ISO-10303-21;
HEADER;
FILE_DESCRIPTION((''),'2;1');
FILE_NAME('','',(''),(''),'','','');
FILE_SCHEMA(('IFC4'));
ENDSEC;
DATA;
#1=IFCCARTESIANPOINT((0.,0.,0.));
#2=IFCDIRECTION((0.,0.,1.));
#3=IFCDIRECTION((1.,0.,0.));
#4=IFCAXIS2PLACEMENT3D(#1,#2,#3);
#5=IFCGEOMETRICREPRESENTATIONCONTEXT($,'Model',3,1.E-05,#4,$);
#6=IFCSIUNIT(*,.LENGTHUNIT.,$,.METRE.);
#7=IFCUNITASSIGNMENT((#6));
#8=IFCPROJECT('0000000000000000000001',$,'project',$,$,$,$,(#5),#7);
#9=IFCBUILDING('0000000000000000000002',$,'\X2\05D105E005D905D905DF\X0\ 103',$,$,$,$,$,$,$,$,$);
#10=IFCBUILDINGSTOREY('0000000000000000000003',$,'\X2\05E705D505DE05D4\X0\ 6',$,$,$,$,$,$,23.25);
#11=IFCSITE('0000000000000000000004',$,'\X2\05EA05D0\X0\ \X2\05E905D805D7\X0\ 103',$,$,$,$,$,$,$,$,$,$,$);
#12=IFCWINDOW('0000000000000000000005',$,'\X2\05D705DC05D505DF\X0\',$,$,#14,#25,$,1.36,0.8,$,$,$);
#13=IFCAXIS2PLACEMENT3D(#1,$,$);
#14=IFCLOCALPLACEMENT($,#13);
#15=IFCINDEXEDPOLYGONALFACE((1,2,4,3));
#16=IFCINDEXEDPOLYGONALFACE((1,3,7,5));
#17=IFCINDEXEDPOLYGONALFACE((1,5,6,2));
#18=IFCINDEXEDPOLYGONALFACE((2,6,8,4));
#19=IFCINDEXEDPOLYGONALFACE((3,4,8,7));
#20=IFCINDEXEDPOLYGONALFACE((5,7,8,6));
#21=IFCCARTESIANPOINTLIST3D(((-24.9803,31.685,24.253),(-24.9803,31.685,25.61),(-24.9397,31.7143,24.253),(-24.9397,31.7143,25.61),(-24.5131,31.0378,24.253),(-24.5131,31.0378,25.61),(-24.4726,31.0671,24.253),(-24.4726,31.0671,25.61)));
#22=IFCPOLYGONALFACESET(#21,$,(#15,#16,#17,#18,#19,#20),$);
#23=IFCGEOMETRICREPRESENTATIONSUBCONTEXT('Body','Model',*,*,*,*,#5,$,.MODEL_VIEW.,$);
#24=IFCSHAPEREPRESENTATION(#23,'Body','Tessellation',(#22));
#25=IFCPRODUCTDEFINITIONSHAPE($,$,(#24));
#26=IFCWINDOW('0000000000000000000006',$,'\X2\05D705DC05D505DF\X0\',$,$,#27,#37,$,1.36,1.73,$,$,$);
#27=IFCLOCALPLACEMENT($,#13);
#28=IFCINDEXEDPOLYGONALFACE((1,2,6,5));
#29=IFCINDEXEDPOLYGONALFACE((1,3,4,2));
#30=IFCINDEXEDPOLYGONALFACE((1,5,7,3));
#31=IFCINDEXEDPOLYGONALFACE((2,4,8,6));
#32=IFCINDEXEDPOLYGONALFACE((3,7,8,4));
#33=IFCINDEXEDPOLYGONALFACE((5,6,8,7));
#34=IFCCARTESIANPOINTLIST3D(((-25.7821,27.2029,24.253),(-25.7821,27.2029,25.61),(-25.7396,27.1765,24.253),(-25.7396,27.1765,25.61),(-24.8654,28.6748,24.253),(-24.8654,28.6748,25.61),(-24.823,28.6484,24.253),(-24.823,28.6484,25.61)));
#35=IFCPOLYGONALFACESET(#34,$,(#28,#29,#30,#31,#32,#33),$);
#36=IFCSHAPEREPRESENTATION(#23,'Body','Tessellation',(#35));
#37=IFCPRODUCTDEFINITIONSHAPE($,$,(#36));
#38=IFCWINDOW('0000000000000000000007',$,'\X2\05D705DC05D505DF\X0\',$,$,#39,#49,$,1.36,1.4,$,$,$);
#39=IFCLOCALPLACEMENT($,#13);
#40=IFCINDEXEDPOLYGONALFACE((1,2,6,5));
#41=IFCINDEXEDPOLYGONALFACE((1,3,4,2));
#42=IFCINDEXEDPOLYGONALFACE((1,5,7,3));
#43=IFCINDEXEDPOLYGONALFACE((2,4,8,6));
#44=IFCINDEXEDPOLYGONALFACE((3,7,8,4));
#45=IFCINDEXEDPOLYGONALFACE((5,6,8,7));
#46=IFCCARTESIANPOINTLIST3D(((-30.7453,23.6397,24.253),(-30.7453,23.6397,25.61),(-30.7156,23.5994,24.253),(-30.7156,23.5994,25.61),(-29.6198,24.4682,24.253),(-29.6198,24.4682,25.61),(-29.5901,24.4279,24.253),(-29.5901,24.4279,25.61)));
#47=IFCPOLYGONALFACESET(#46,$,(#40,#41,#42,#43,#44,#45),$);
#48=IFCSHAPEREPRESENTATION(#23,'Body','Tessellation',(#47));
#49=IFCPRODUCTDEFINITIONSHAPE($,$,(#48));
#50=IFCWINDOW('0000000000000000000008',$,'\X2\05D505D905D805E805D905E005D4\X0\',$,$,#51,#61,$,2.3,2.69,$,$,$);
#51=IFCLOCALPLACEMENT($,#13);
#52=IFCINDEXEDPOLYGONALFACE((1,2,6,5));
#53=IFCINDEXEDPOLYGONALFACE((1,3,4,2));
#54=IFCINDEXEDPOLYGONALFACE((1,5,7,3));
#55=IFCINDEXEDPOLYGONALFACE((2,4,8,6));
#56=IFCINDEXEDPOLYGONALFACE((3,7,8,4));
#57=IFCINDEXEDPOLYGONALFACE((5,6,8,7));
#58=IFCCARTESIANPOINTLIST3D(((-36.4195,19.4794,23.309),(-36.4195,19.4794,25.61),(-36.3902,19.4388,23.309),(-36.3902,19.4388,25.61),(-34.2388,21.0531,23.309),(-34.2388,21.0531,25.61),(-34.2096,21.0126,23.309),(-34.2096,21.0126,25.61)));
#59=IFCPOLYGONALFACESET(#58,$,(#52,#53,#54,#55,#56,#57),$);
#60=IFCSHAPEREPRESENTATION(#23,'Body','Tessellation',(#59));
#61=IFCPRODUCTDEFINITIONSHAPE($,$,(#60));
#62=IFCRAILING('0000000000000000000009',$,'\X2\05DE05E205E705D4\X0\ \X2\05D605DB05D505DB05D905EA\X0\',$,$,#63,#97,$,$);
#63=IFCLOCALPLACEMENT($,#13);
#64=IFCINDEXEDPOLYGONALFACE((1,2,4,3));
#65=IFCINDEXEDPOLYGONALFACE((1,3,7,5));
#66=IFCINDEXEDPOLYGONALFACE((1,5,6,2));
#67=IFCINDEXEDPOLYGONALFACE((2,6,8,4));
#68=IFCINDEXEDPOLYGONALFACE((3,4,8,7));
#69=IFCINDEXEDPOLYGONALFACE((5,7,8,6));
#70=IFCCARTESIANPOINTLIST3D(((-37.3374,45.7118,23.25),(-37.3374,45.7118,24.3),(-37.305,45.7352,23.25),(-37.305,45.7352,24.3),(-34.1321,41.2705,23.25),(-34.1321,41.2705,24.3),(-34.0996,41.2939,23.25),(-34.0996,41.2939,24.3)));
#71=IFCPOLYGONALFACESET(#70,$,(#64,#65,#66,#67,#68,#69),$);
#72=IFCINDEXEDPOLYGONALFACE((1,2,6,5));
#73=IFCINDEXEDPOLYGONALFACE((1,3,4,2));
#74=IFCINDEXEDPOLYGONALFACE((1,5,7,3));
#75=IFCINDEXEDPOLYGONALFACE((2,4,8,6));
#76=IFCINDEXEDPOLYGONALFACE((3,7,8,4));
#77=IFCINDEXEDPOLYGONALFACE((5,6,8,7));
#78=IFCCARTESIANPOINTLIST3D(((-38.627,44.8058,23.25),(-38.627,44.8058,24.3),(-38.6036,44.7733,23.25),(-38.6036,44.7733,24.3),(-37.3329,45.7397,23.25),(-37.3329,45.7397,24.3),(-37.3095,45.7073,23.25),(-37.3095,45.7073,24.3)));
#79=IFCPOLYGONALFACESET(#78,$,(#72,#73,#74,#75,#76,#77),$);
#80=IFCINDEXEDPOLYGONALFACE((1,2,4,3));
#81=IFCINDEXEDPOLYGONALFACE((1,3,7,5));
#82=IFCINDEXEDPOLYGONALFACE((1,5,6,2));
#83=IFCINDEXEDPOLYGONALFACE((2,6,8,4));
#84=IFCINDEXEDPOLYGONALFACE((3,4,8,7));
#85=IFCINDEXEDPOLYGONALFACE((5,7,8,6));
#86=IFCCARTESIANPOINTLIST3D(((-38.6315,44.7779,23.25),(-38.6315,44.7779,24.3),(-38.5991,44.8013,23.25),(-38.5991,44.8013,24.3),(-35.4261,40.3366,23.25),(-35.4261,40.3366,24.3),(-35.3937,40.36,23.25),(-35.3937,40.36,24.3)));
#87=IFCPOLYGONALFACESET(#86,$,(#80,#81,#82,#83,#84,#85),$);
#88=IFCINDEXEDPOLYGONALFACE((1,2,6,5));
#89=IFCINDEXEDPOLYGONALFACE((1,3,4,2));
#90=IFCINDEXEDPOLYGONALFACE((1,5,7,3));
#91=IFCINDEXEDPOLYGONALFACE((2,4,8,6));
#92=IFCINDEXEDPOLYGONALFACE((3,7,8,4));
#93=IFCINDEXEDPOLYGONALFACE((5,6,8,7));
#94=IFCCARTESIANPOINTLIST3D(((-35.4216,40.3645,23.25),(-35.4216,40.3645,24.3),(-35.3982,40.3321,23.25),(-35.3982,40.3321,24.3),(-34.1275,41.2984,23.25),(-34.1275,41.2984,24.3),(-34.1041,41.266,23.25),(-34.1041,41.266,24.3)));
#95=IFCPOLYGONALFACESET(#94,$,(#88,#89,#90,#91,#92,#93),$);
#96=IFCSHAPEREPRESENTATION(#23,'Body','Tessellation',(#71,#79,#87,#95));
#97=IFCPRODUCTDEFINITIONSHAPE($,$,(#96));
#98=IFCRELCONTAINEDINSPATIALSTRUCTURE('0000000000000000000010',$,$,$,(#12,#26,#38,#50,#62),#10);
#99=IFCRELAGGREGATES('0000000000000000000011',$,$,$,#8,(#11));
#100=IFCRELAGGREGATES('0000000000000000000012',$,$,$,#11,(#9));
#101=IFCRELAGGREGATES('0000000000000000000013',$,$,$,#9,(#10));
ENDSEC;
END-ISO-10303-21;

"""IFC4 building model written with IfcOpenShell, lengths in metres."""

from ifc_helpers import new_model, si_unit, frame, origin_with_axes, context, subcontext, project, spatial, polyline, outline, extrude, element, save


model = new_model("IFC4")

# Units and contexts
model_context = context("Model", 3, precision=1e-05, world=origin_with_axes())
body_context = subcontext(model_context, "Body", "Model", "MODEL_VIEW")
ifc_project = project(units=[si_unit("LENGTHUNIT", "METRE")], contexts=[model_context])

# Site, building, storey
site = spatial("IfcSite", under=ifc_project, Name="תא שטח 103")
building = spatial("IfcBuilding", under=site, Name="בניין 103")
storey = spatial("IfcBuildingStorey", under=building, Name="קומה 6", Elevation=23.25)

# Windows
element("IfcWindow", 1, inside=storey, Name="חלון", OverallHeight=1.36, OverallWidth=0.8, context=body_context, shape_type="SweptSolid", body=[
    extrude(outline(polyline([(-24.9803, 31.685), (-24.5131, 31.0378), (-24.4726, 31.0671), (-24.9397, 31.7143), (-24.9803, 31.685)])), frame((0.0, 0.0, 24.253)), (0.0, 0.0, 1.0), 1.357),
])
element("IfcWindow", 2, inside=storey, Name="חלון", OverallHeight=1.36, OverallWidth=1.73, context=body_context, shape_type="SweptSolid", body=[
    extrude(outline(polyline([(-24.8654, 28.6748), (-25.7821, 27.2029), (-25.7396, 27.1765), (-24.823, 28.6484), (-24.8654, 28.6748)])), frame((0.0, 0.0, 24.253)), (0.0, 0.0, 1.0), 1.357),
])
element("IfcWindow", 3, inside=storey, Name="חלון", OverallHeight=1.36, OverallWidth=1.4, context=body_context, shape_type="SweptSolid", body=[
    extrude(outline(polyline([(-29.6198, 24.4682), (-30.7453, 23.6397), (-30.7156, 23.5994), (-29.5901, 24.4279), (-29.6198, 24.4682)])), frame((0.0, 0.0, 24.253)), (0.0, 0.0, 1.0), 1.357),
])
element("IfcWindow", 4, inside=storey, Name="ויטרינה", OverallHeight=2.3, OverallWidth=2.69, context=body_context, shape_type="SweptSolid", body=[
    extrude(outline(polyline([(-34.2388, 21.0531), (-36.4195, 19.4794), (-36.3902, 19.4388), (-34.2096, 21.0126), (-34.2388, 21.0531)])), frame((0.0, 0.0, 23.309)), (0.0, 0.0, 1.0), 2.301),
])

# Railing
element("IfcRailing", 5, inside=storey, Name="מעקה זכוכית", context=body_context, shape_type="SweptSolid", body=[
    extrude(outline(polyline([(-34.0996, 41.2939), (-37.305, 45.7352), (-37.3374, 45.7118), (-34.1321, 41.2705), (-34.0996, 41.2939)])), frame((0.0, 0.0, 23.25)), (0.0, 0.0, 1.0), 1.05),
    extrude(outline(polyline([(-37.3329, 45.7397), (-38.627, 44.8058), (-38.6036, 44.7733), (-37.3095, 45.7073), (-37.3329, 45.7397)])), frame((0.0, 0.0, 23.25)), (0.0, 0.0, 1.0), 1.05),
    extrude(outline(polyline([(-38.6315, 44.7779), (-35.4261, 40.3366), (-35.3937, 40.36), (-38.5991, 44.8013), (-38.6315, 44.7779)])), frame((0.0, 0.0, 23.25)), (0.0, 0.0, 1.0), 1.05),
    extrude(outline(polyline([(-35.3982, 40.3321), (-34.1041, 41.266), (-34.1275, 41.2984), (-35.4216, 40.3645), (-35.3982, 40.3321)])), frame((0.0, 0.0, 23.25)), (0.0, 0.0, 1.0), 1.05),
])

save(model, "model.ifc")
